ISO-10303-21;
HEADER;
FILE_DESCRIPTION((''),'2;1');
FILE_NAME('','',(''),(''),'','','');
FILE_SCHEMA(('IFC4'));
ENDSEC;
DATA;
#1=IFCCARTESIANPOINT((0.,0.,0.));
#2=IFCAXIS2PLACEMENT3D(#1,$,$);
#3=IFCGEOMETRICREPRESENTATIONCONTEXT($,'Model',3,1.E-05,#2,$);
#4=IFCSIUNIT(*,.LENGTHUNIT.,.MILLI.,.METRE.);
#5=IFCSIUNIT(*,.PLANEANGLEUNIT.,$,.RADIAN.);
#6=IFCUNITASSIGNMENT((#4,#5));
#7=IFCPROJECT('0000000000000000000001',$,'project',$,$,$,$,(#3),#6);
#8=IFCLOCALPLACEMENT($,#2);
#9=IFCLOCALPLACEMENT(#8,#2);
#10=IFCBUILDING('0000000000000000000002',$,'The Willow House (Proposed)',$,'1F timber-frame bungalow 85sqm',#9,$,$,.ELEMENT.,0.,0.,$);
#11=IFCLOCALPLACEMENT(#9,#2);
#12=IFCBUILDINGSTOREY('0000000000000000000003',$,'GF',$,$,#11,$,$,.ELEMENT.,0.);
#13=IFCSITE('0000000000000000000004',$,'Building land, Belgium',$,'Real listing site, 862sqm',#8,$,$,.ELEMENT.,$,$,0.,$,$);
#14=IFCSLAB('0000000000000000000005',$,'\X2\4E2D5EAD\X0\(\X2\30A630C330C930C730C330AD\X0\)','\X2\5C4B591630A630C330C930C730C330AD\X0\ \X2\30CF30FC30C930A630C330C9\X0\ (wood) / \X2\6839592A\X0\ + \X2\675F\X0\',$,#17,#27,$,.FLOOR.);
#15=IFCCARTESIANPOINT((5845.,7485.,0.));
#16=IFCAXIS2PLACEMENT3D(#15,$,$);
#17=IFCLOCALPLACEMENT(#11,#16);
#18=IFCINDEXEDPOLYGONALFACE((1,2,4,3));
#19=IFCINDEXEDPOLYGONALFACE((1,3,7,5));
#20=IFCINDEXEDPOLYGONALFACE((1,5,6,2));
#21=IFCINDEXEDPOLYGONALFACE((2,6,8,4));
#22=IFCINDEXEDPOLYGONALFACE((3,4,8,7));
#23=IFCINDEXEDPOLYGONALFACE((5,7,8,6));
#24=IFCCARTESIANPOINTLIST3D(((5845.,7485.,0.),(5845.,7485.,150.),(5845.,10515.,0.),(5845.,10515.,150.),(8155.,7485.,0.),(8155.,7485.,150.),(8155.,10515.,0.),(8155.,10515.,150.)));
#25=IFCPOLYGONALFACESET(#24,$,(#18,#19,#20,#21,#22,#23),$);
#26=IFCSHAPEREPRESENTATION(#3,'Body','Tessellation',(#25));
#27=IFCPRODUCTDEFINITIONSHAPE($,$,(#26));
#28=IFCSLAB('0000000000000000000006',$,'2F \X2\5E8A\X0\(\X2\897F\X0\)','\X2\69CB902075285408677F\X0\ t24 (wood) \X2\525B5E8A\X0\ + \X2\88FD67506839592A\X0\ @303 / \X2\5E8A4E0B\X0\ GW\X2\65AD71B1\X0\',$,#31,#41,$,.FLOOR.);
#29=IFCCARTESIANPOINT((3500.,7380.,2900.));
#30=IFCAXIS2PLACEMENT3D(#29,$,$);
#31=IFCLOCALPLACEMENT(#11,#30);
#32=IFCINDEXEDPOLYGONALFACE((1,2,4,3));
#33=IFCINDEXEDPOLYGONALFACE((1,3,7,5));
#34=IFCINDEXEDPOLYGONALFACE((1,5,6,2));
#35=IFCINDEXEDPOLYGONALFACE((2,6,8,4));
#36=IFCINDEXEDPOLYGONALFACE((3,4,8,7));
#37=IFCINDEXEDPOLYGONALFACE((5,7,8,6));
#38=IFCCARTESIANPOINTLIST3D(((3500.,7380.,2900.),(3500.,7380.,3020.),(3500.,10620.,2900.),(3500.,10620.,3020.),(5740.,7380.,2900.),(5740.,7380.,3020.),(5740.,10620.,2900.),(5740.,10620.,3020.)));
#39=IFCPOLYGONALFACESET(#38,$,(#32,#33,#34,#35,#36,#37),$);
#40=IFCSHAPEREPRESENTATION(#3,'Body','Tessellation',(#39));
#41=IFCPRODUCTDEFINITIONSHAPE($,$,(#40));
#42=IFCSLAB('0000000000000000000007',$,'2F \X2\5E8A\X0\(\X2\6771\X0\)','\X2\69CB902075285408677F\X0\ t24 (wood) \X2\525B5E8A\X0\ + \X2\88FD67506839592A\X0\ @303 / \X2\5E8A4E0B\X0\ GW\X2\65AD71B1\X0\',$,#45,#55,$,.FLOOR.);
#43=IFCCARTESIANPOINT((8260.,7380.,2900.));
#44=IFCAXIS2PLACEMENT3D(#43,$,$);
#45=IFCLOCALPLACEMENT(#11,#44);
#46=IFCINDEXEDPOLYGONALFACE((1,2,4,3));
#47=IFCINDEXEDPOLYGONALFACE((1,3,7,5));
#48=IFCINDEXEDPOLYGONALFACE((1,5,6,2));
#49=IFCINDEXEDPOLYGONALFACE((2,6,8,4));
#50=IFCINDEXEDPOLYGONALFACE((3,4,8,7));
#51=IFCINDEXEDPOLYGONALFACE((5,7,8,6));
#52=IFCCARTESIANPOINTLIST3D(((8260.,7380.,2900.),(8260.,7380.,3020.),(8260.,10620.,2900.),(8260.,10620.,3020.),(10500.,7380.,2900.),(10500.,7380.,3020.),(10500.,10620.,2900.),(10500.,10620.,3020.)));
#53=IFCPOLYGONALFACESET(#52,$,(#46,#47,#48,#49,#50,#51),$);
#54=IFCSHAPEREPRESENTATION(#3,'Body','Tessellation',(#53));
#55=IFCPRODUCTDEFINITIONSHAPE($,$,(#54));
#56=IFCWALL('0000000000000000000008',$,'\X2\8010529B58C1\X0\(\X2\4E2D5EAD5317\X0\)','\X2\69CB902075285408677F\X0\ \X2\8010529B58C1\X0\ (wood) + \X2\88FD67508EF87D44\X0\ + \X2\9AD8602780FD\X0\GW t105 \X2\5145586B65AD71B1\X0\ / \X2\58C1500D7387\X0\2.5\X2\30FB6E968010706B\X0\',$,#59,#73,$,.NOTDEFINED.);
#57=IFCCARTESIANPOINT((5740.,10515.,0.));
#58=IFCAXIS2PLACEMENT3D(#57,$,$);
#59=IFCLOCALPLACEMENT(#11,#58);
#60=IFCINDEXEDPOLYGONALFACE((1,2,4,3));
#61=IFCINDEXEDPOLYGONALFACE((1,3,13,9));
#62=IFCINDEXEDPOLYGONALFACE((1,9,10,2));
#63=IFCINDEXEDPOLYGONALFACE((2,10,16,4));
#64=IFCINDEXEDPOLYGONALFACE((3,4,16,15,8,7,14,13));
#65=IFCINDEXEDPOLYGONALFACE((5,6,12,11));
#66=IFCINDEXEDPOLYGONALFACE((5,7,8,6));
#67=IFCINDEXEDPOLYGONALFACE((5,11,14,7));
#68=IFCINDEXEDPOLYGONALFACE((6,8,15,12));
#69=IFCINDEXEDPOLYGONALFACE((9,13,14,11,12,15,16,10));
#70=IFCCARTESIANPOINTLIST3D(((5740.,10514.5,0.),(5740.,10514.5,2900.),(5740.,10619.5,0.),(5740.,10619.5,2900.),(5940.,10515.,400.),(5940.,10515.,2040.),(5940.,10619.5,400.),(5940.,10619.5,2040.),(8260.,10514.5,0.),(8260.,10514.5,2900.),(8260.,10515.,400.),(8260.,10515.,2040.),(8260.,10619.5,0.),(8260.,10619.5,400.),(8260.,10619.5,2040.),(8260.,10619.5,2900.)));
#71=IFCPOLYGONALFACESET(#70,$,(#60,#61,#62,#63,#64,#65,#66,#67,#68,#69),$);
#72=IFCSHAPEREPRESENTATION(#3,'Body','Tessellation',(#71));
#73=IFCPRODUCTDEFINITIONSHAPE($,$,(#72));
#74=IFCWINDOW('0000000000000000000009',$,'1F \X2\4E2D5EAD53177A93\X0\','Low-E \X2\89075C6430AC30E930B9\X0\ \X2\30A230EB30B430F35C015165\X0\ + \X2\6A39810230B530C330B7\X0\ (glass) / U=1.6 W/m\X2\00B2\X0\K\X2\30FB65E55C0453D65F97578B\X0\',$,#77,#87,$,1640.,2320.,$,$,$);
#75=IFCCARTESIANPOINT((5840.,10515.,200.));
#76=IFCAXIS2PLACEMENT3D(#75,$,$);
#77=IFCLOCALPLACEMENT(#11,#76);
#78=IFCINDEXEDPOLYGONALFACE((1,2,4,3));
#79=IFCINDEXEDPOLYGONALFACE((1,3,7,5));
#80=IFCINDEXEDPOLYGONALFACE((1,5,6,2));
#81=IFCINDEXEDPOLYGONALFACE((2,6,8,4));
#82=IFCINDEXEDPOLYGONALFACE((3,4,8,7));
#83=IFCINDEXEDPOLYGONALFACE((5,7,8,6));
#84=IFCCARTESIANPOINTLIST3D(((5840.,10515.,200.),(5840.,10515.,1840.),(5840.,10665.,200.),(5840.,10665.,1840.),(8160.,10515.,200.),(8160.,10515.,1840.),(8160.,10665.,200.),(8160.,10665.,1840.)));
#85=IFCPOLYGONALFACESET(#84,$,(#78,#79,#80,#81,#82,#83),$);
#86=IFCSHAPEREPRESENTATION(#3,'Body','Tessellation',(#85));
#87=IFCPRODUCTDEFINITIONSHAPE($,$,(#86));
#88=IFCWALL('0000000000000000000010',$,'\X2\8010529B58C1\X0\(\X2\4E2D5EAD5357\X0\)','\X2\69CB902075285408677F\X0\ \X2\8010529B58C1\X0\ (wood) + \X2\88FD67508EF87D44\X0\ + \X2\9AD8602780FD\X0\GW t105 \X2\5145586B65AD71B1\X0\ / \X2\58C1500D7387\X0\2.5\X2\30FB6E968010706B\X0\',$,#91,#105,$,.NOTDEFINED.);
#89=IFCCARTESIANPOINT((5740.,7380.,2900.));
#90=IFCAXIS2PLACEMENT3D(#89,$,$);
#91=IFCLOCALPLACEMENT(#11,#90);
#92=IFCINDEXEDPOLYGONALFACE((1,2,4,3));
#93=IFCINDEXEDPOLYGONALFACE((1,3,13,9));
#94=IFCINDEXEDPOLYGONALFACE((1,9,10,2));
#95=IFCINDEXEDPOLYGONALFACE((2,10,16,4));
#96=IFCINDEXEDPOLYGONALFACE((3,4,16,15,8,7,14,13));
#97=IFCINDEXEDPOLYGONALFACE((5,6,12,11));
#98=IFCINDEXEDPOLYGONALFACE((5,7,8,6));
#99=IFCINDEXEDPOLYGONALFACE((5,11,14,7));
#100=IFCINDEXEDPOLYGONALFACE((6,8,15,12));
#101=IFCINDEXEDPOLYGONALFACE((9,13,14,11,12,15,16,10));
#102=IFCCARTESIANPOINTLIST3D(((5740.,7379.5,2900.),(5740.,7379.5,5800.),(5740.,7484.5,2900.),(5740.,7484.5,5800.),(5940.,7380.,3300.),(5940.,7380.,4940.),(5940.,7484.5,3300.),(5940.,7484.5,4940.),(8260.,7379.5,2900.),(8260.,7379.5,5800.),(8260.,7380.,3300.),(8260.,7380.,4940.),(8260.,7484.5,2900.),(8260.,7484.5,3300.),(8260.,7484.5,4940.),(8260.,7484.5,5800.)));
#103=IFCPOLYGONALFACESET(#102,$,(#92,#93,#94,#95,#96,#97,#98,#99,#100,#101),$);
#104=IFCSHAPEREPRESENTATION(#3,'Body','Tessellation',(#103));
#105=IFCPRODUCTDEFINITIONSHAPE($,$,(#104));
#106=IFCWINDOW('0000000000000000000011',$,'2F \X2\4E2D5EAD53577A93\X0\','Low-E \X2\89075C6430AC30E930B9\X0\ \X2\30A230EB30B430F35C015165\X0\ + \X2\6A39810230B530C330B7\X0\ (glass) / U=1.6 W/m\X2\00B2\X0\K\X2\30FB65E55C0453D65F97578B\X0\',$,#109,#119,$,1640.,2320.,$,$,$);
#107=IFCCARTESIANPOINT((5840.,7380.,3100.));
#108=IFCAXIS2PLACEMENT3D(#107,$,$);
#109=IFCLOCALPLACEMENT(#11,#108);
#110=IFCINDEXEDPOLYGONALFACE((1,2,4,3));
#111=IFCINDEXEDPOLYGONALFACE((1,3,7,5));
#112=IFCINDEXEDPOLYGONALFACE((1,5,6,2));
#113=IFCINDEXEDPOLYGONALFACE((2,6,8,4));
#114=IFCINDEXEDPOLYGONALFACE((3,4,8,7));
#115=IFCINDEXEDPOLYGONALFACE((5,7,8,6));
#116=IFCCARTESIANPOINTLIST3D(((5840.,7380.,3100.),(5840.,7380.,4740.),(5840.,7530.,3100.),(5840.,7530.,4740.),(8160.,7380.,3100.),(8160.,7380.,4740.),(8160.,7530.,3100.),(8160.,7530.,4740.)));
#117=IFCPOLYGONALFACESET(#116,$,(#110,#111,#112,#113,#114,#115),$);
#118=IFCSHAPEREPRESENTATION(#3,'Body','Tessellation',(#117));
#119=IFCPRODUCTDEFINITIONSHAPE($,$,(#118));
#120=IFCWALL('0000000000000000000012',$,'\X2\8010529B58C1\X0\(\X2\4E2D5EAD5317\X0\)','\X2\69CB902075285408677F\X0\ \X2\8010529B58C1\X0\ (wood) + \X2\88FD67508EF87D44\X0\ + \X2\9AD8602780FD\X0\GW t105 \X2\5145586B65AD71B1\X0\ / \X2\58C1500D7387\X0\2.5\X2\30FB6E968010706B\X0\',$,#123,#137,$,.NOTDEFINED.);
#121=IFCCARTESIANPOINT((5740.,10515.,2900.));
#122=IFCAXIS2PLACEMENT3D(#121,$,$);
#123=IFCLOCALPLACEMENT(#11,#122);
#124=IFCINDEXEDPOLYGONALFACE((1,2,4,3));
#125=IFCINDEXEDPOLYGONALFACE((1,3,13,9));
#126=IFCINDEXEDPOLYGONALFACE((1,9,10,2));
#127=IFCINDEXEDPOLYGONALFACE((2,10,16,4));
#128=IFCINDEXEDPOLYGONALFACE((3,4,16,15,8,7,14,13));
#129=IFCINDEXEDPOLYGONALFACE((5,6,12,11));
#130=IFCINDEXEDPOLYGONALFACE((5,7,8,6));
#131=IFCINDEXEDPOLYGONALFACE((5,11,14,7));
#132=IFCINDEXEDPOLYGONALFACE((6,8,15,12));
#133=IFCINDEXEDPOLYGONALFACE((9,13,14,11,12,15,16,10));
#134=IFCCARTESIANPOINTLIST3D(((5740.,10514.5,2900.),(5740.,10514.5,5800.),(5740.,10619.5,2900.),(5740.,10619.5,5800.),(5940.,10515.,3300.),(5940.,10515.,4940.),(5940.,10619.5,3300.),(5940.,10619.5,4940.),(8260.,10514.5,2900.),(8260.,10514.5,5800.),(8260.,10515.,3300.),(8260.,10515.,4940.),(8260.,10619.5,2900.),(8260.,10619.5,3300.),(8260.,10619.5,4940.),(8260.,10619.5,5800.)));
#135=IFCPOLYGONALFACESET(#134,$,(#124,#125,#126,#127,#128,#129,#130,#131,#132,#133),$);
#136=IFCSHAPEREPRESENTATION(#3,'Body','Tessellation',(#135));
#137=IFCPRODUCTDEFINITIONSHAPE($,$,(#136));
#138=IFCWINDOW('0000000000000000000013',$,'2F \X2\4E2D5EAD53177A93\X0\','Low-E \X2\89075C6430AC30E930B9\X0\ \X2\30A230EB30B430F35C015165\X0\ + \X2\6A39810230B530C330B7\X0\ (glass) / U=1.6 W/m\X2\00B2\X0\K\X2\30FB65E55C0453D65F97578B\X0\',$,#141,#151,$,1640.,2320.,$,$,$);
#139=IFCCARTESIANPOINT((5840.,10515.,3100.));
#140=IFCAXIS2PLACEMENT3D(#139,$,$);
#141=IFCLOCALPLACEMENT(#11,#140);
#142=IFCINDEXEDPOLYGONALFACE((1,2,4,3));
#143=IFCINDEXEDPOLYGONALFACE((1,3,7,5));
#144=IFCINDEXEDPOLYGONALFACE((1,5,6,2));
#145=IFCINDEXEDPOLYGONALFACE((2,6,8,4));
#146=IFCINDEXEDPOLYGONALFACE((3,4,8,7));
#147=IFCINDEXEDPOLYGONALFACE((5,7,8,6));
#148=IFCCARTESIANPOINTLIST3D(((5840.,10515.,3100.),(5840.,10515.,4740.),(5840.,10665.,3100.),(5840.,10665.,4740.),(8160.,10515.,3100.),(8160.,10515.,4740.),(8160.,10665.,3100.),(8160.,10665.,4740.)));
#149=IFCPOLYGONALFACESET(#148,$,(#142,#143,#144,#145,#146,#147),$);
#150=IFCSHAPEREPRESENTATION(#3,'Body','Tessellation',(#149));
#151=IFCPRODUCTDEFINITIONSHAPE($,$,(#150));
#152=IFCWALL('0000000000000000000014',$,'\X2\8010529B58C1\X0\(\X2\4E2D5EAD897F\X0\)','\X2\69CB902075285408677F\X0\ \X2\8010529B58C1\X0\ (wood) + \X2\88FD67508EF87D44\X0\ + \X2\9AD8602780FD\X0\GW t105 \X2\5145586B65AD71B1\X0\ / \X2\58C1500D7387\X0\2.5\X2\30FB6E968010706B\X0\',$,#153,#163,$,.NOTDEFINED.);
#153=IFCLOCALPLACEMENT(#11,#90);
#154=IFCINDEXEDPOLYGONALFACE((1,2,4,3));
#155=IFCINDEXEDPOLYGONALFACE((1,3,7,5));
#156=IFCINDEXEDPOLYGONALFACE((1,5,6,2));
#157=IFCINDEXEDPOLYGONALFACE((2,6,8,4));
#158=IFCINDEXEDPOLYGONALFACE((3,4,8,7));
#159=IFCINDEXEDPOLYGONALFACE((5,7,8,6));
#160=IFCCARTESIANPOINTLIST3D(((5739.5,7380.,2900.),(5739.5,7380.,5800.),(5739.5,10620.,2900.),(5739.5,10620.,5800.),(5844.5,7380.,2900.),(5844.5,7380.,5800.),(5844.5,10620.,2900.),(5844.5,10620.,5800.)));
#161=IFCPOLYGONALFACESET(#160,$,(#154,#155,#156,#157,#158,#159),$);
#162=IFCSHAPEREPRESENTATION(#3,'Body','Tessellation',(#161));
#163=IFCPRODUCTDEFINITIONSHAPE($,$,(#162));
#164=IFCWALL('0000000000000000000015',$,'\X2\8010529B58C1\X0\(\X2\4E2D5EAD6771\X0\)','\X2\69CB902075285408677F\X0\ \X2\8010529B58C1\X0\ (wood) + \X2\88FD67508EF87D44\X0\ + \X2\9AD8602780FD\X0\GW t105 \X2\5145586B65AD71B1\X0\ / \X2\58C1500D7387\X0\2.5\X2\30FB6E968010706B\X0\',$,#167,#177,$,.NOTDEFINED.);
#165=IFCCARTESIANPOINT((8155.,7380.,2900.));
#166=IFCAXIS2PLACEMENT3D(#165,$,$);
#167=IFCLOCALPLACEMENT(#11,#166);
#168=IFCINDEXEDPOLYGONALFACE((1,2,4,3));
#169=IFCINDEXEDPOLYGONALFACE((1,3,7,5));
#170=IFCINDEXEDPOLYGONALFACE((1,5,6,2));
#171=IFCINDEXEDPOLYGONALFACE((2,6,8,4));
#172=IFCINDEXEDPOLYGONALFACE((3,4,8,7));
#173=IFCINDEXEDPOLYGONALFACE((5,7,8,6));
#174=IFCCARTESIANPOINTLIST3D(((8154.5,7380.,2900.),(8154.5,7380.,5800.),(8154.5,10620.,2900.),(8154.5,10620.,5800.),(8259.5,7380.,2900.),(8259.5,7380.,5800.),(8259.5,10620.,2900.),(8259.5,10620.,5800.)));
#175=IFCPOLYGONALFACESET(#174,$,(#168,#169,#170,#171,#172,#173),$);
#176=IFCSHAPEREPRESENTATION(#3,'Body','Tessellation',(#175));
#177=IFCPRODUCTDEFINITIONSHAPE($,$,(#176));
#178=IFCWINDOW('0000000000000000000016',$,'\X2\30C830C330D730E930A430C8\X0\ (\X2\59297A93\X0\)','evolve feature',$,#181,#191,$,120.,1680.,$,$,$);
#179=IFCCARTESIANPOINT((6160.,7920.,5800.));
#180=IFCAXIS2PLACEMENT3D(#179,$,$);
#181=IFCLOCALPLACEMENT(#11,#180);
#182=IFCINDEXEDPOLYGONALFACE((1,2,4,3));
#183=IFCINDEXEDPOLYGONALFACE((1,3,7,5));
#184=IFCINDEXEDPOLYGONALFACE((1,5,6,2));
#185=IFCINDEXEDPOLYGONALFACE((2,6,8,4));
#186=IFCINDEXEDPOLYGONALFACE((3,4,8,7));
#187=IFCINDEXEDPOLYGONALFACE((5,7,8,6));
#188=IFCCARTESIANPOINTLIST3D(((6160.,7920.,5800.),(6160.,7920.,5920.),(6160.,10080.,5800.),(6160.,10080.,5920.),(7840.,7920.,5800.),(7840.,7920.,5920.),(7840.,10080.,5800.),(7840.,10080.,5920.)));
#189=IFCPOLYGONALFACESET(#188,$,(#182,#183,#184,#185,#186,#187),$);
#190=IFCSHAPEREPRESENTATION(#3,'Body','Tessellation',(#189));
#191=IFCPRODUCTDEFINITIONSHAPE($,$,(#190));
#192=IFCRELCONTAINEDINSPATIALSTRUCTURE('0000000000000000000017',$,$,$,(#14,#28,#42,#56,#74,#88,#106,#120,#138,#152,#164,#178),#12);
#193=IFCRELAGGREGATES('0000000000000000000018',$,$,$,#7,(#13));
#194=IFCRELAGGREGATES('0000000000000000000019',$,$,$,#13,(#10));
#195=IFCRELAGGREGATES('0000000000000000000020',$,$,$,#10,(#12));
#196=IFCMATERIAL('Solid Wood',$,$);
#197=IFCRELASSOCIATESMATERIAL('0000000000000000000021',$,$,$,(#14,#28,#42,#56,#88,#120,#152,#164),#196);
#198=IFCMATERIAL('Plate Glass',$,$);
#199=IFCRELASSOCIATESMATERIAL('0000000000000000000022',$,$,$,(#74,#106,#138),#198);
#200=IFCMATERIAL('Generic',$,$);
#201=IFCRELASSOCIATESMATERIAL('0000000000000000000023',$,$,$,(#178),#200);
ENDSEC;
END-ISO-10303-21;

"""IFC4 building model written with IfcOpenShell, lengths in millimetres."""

from ifc_helpers import new_model, si_unit, frame, frame_2d, origin, place, context, project, spatial, rectangle, extrude, material, element, fill, save


model = new_model("IFC4")

# Units and contexts
model_context = context("Model", 3, precision=1e-05, world=origin())
ifc_project = project(units=[si_unit("LENGTHUNIT", "METRE", prefix="MILLI"), si_unit("PLANEANGLEUNIT", "RADIAN")], contexts=[model_context])

# Site, building, storey
site_placement = place(None, origin())
site = spatial("IfcSite", under=ifc_project, at=site_placement, Name="Building land, Belgium", ObjectType="Real listing site, 862sqm", CompositionType="ELEMENT", RefElevation=0.0)
building_placement = place(site_placement, origin())
building = spatial("IfcBuilding", under=site, at=building_placement, Name="The Willow House (Proposed)", ObjectType="1F timber-frame bungalow 85sqm", CompositionType="ELEMENT", ElevationOfRefHeight=0.0, ElevationOfTerrain=0.0)
storey_placement = place(building_placement, origin())
storey = spatial("IfcBuildingStorey", under=building, at=storey_placement, Name="GF", CompositionType="ELEMENT", Elevation=0.0)

# Slabs
ifc_material_1 = material(Name="Solid Wood")
slab_1_placement = place(storey_placement, frame((5845.0, 7485.0, 0.0)))
element("IfcSlab", 1, at=slab_1_placement, inside=storey, material=ifc_material_1, Name="中庭(ウッドデッキ)", Description="屋外ウッドデッキ ハードウッド (wood) / 根太 + 束", PredefinedType="FLOOR", context=model_context, shape_type="SweptSolid", body=[
    extrude(rectangle(XDim=2310.0, YDim=3030.0, at=frame_2d((1155.0, 1515.0))), frame((5845.0, 7485.0, 0.0)), (0.0, 0.0, 1.0), 150.0),
])
slab_2_placement = place(storey_placement, frame((3500.0, 7380.0, 2900.0)))
element("IfcSlab", 2, at=slab_2_placement, inside=storey, material=ifc_material_1, Name="2F 床(西)", Description="構造用合板 t24 (wood) 剛床 + 製材根太 @303 / 床下 GW断熱", PredefinedType="FLOOR", context=model_context, shape_type="SweptSolid", body=[
    extrude(rectangle(XDim=2240.0, YDim=3240.0, at=frame_2d((1120.0, 1620.0))), frame((3500.0, 7380.0, 2900.0)), (0.0, 0.0, 1.0), 120.0),
])
slab_3_placement = place(storey_placement, frame((8260.0, 7380.0, 2900.0)))
element("IfcSlab", 3, at=slab_3_placement, inside=storey, material=ifc_material_1, Name="2F 床(東)", Description="構造用合板 t24 (wood) 剛床 + 製材根太 @303 / 床下 GW断熱", PredefinedType="FLOOR", context=model_context, shape_type="SweptSolid", body=[
    extrude(rectangle(XDim=2240.0, YDim=3240.0, at=frame_2d((1120.0, 1620.0))), frame((8260.0, 7380.0, 2900.0)), (0.0, 0.0, 1.0), 120.0),
])

# Walls, openings, windows
wall_1_placement = place(storey_placement, frame((5740.0, 10515.0, 0.0)))
wall_1 = element("IfcWall", 4, at=wall_1_placement, inside=storey, material=ifc_material_1, Name="耐力壁(中庭北)", Description="構造用合板 耐力壁 (wood) + 製材軸組 + 高性能GW t105 充填断熱 / 壁倍率2.5・準耐火", PredefinedType="NOTDEFINED", context=model_context, shape_type="SweptSolid", body=[
    extrude(rectangle(XDim=2520.0, YDim=105.0, at=frame_2d((1260.0, 52.0))), frame((5740.0, 10515.0, 0.0)), (0.0, 0.0, 1.0), 2900.0),
])
opening_1_placement = place(storey_placement, frame((5840.0, 10515.0, 200.0)))
opening_1 = element("IfcOpeningElement", 5, at=opening_1_placement, cuts=wall_1, PredefinedType="NOTDEFINED", context=model_context, shape_type="SweptSolid", body=[
    extrude(rectangle(XDim=2320.0, YDim=150.0, at=frame_2d((1160.0, 75.0))), frame((5840.0, 10515.0, 200.0)), (0.0, 0.0, 1.0), 1640.0),
])
ifc_material_2 = material(Name="Plate Glass")
window_1_placement = place(storey_placement, frame((5840.0, 10515.0, 200.0)))
window_1 = element("IfcWindow", 6, at=window_1_placement, inside=storey, material=ifc_material_2, Name="1F 中庭北窓", Description="Low-E 複層ガラス アルゴン封入 + 樹脂サッシ (glass) / U=1.6 W/m²K・日射取得型", OverallHeight=1640.0, OverallWidth=2320.0, context=model_context, shape_type="SweptSolid", body=[
    extrude(rectangle(XDim=2320.0, YDim=150.0, at=frame_2d((1160.0, 75.0))), frame((5840.0, 10515.0, 200.0)), (0.0, 0.0, 1.0), 1640.0),
])
fill(opening_1, window_1)
wall_2_placement = place(storey_placement, frame((5740.0, 7380.0, 2900.0)))
wall_2 = element("IfcWall", 7, at=wall_2_placement, inside=storey, material=ifc_material_1, Name="耐力壁(中庭南)", Description="構造用合板 耐力壁 (wood) + 製材軸組 + 高性能GW t105 充填断熱 / 壁倍率2.5・準耐火", PredefinedType="NOTDEFINED", context=model_context, shape_type="SweptSolid", body=[
    extrude(rectangle(XDim=2520.0, YDim=105.0, at=frame_2d((1260.0, 52.0))), frame((5740.0, 7380.0, 2900.0)), (0.0, 0.0, 1.0), 2900.0),
])
opening_2_placement = place(storey_placement, frame((5840.0, 7380.0, 3100.0)))
opening_2 = element("IfcOpeningElement", 8, at=opening_2_placement, cuts=wall_2, PredefinedType="NOTDEFINED", context=model_context, shape_type="SweptSolid", body=[
    extrude(rectangle(XDim=2320.0, YDim=150.0, at=frame_2d((1160.0, 75.0))), frame((5840.0, 7380.0, 3100.0)), (0.0, 0.0, 1.0), 1640.0),
])
window_2_placement = place(storey_placement, frame((5840.0, 7380.0, 3100.0)))
window_2 = element("IfcWindow", 9, at=window_2_placement, inside=storey, material=ifc_material_2, Name="2F 中庭南窓", Description="Low-E 複層ガラス アルゴン封入 + 樹脂サッシ (glass) / U=1.6 W/m²K・日射取得型", OverallHeight=1640.0, OverallWidth=2320.0, context=model_context, shape_type="SweptSolid", body=[
    extrude(rectangle(XDim=2320.0, YDim=150.0, at=frame_2d((1160.0, 75.0))), frame((5840.0, 7380.0, 3100.0)), (0.0, 0.0, 1.0), 1640.0),
])
fill(opening_2, window_2)
wall_3_placement = place(storey_placement, frame((5740.0, 10515.0, 2900.0)))
wall_3 = element("IfcWall", 10, at=wall_3_placement, inside=storey, material=ifc_material_1, Name="耐力壁(中庭北)", Description="構造用合板 耐力壁 (wood) + 製材軸組 + 高性能GW t105 充填断熱 / 壁倍率2.5・準耐火", PredefinedType="NOTDEFINED", context=model_context, shape_type="SweptSolid", body=[
    extrude(rectangle(XDim=2520.0, YDim=105.0, at=frame_2d((1260.0, 52.0))), frame((5740.0, 10515.0, 2900.0)), (0.0, 0.0, 1.0), 2900.0),
])
opening_3_placement = place(storey_placement, frame((5840.0, 10515.0, 3100.0)))
opening_3 = element("IfcOpeningElement", 11, at=opening_3_placement, cuts=wall_3, PredefinedType="NOTDEFINED", context=model_context, shape_type="SweptSolid", body=[
    extrude(rectangle(XDim=2320.0, YDim=150.0, at=frame_2d((1160.0, 75.0))), frame((5840.0, 10515.0, 3100.0)), (0.0, 0.0, 1.0), 1640.0),
])
window_3_placement = place(storey_placement, frame((5840.0, 10515.0, 3100.0)))
window_3 = element("IfcWindow", 12, at=window_3_placement, inside=storey, material=ifc_material_2, Name="2F 中庭北窓", Description="Low-E 複層ガラス アルゴン封入 + 樹脂サッシ (glass) / U=1.6 W/m²K・日射取得型", OverallHeight=1640.0, OverallWidth=2320.0, context=model_context, shape_type="SweptSolid", body=[
    extrude(rectangle(XDim=2320.0, YDim=150.0, at=frame_2d((1160.0, 75.0))), frame((5840.0, 10515.0, 3100.0)), (0.0, 0.0, 1.0), 1640.0),
])
fill(opening_3, window_3)

# Walls
wall_4_placement = place(storey_placement, frame((5740.0, 7380.0, 2900.0)))
element("IfcWall", 13, at=wall_4_placement, inside=storey, material=ifc_material_1, Name="耐力壁(中庭西)", Description="構造用合板 耐力壁 (wood) + 製材軸組 + 高性能GW t105 充填断熱 / 壁倍率2.5・準耐火", PredefinedType="NOTDEFINED", context=model_context, shape_type="SweptSolid", body=[
    extrude(rectangle(XDim=105.0, YDim=3240.0, at=frame_2d((52.0, 1620.0))), frame((5740.0, 7380.0, 2900.0)), (0.0, 0.0, 1.0), 2900.0),
])
wall_5_placement = place(storey_placement, frame((8155.0, 7380.0, 2900.0)))
element("IfcWall", 14, at=wall_5_placement, inside=storey, material=ifc_material_1, Name="耐力壁(中庭東)", Description="構造用合板 耐力壁 (wood) + 製材軸組 + 高性能GW t105 充填断熱 / 壁倍率2.5・準耐火", PredefinedType="NOTDEFINED", context=model_context, shape_type="SweptSolid", body=[
    extrude(rectangle(XDim=105.0, YDim=3240.0, at=frame_2d((52.0, 1620.0))), frame((8155.0, 7380.0, 2900.0)), (0.0, 0.0, 1.0), 2900.0),
])

# Window
ifc_material_3 = material(Name="Generic")
window_4_placement = place(storey_placement, frame((6160.0, 7920.0, 5800.0)))
element("IfcWindow", 15, at=window_4_placement, inside=storey, material=ifc_material_3, Name="トップライト (天窓)", Description="evolve feature", OverallHeight=120.0, OverallWidth=1680.0, context=model_context, shape_type="SweptSolid", body=[
    extrude(rectangle(XDim=1680.0, YDim=2160.0, at=frame_2d((840.0, 1080.0))), frame((6160.0, 7920.0, 5800.0)), (0.0, 0.0, 1.0), 120.0),
])

save(model, "model.ifc")
